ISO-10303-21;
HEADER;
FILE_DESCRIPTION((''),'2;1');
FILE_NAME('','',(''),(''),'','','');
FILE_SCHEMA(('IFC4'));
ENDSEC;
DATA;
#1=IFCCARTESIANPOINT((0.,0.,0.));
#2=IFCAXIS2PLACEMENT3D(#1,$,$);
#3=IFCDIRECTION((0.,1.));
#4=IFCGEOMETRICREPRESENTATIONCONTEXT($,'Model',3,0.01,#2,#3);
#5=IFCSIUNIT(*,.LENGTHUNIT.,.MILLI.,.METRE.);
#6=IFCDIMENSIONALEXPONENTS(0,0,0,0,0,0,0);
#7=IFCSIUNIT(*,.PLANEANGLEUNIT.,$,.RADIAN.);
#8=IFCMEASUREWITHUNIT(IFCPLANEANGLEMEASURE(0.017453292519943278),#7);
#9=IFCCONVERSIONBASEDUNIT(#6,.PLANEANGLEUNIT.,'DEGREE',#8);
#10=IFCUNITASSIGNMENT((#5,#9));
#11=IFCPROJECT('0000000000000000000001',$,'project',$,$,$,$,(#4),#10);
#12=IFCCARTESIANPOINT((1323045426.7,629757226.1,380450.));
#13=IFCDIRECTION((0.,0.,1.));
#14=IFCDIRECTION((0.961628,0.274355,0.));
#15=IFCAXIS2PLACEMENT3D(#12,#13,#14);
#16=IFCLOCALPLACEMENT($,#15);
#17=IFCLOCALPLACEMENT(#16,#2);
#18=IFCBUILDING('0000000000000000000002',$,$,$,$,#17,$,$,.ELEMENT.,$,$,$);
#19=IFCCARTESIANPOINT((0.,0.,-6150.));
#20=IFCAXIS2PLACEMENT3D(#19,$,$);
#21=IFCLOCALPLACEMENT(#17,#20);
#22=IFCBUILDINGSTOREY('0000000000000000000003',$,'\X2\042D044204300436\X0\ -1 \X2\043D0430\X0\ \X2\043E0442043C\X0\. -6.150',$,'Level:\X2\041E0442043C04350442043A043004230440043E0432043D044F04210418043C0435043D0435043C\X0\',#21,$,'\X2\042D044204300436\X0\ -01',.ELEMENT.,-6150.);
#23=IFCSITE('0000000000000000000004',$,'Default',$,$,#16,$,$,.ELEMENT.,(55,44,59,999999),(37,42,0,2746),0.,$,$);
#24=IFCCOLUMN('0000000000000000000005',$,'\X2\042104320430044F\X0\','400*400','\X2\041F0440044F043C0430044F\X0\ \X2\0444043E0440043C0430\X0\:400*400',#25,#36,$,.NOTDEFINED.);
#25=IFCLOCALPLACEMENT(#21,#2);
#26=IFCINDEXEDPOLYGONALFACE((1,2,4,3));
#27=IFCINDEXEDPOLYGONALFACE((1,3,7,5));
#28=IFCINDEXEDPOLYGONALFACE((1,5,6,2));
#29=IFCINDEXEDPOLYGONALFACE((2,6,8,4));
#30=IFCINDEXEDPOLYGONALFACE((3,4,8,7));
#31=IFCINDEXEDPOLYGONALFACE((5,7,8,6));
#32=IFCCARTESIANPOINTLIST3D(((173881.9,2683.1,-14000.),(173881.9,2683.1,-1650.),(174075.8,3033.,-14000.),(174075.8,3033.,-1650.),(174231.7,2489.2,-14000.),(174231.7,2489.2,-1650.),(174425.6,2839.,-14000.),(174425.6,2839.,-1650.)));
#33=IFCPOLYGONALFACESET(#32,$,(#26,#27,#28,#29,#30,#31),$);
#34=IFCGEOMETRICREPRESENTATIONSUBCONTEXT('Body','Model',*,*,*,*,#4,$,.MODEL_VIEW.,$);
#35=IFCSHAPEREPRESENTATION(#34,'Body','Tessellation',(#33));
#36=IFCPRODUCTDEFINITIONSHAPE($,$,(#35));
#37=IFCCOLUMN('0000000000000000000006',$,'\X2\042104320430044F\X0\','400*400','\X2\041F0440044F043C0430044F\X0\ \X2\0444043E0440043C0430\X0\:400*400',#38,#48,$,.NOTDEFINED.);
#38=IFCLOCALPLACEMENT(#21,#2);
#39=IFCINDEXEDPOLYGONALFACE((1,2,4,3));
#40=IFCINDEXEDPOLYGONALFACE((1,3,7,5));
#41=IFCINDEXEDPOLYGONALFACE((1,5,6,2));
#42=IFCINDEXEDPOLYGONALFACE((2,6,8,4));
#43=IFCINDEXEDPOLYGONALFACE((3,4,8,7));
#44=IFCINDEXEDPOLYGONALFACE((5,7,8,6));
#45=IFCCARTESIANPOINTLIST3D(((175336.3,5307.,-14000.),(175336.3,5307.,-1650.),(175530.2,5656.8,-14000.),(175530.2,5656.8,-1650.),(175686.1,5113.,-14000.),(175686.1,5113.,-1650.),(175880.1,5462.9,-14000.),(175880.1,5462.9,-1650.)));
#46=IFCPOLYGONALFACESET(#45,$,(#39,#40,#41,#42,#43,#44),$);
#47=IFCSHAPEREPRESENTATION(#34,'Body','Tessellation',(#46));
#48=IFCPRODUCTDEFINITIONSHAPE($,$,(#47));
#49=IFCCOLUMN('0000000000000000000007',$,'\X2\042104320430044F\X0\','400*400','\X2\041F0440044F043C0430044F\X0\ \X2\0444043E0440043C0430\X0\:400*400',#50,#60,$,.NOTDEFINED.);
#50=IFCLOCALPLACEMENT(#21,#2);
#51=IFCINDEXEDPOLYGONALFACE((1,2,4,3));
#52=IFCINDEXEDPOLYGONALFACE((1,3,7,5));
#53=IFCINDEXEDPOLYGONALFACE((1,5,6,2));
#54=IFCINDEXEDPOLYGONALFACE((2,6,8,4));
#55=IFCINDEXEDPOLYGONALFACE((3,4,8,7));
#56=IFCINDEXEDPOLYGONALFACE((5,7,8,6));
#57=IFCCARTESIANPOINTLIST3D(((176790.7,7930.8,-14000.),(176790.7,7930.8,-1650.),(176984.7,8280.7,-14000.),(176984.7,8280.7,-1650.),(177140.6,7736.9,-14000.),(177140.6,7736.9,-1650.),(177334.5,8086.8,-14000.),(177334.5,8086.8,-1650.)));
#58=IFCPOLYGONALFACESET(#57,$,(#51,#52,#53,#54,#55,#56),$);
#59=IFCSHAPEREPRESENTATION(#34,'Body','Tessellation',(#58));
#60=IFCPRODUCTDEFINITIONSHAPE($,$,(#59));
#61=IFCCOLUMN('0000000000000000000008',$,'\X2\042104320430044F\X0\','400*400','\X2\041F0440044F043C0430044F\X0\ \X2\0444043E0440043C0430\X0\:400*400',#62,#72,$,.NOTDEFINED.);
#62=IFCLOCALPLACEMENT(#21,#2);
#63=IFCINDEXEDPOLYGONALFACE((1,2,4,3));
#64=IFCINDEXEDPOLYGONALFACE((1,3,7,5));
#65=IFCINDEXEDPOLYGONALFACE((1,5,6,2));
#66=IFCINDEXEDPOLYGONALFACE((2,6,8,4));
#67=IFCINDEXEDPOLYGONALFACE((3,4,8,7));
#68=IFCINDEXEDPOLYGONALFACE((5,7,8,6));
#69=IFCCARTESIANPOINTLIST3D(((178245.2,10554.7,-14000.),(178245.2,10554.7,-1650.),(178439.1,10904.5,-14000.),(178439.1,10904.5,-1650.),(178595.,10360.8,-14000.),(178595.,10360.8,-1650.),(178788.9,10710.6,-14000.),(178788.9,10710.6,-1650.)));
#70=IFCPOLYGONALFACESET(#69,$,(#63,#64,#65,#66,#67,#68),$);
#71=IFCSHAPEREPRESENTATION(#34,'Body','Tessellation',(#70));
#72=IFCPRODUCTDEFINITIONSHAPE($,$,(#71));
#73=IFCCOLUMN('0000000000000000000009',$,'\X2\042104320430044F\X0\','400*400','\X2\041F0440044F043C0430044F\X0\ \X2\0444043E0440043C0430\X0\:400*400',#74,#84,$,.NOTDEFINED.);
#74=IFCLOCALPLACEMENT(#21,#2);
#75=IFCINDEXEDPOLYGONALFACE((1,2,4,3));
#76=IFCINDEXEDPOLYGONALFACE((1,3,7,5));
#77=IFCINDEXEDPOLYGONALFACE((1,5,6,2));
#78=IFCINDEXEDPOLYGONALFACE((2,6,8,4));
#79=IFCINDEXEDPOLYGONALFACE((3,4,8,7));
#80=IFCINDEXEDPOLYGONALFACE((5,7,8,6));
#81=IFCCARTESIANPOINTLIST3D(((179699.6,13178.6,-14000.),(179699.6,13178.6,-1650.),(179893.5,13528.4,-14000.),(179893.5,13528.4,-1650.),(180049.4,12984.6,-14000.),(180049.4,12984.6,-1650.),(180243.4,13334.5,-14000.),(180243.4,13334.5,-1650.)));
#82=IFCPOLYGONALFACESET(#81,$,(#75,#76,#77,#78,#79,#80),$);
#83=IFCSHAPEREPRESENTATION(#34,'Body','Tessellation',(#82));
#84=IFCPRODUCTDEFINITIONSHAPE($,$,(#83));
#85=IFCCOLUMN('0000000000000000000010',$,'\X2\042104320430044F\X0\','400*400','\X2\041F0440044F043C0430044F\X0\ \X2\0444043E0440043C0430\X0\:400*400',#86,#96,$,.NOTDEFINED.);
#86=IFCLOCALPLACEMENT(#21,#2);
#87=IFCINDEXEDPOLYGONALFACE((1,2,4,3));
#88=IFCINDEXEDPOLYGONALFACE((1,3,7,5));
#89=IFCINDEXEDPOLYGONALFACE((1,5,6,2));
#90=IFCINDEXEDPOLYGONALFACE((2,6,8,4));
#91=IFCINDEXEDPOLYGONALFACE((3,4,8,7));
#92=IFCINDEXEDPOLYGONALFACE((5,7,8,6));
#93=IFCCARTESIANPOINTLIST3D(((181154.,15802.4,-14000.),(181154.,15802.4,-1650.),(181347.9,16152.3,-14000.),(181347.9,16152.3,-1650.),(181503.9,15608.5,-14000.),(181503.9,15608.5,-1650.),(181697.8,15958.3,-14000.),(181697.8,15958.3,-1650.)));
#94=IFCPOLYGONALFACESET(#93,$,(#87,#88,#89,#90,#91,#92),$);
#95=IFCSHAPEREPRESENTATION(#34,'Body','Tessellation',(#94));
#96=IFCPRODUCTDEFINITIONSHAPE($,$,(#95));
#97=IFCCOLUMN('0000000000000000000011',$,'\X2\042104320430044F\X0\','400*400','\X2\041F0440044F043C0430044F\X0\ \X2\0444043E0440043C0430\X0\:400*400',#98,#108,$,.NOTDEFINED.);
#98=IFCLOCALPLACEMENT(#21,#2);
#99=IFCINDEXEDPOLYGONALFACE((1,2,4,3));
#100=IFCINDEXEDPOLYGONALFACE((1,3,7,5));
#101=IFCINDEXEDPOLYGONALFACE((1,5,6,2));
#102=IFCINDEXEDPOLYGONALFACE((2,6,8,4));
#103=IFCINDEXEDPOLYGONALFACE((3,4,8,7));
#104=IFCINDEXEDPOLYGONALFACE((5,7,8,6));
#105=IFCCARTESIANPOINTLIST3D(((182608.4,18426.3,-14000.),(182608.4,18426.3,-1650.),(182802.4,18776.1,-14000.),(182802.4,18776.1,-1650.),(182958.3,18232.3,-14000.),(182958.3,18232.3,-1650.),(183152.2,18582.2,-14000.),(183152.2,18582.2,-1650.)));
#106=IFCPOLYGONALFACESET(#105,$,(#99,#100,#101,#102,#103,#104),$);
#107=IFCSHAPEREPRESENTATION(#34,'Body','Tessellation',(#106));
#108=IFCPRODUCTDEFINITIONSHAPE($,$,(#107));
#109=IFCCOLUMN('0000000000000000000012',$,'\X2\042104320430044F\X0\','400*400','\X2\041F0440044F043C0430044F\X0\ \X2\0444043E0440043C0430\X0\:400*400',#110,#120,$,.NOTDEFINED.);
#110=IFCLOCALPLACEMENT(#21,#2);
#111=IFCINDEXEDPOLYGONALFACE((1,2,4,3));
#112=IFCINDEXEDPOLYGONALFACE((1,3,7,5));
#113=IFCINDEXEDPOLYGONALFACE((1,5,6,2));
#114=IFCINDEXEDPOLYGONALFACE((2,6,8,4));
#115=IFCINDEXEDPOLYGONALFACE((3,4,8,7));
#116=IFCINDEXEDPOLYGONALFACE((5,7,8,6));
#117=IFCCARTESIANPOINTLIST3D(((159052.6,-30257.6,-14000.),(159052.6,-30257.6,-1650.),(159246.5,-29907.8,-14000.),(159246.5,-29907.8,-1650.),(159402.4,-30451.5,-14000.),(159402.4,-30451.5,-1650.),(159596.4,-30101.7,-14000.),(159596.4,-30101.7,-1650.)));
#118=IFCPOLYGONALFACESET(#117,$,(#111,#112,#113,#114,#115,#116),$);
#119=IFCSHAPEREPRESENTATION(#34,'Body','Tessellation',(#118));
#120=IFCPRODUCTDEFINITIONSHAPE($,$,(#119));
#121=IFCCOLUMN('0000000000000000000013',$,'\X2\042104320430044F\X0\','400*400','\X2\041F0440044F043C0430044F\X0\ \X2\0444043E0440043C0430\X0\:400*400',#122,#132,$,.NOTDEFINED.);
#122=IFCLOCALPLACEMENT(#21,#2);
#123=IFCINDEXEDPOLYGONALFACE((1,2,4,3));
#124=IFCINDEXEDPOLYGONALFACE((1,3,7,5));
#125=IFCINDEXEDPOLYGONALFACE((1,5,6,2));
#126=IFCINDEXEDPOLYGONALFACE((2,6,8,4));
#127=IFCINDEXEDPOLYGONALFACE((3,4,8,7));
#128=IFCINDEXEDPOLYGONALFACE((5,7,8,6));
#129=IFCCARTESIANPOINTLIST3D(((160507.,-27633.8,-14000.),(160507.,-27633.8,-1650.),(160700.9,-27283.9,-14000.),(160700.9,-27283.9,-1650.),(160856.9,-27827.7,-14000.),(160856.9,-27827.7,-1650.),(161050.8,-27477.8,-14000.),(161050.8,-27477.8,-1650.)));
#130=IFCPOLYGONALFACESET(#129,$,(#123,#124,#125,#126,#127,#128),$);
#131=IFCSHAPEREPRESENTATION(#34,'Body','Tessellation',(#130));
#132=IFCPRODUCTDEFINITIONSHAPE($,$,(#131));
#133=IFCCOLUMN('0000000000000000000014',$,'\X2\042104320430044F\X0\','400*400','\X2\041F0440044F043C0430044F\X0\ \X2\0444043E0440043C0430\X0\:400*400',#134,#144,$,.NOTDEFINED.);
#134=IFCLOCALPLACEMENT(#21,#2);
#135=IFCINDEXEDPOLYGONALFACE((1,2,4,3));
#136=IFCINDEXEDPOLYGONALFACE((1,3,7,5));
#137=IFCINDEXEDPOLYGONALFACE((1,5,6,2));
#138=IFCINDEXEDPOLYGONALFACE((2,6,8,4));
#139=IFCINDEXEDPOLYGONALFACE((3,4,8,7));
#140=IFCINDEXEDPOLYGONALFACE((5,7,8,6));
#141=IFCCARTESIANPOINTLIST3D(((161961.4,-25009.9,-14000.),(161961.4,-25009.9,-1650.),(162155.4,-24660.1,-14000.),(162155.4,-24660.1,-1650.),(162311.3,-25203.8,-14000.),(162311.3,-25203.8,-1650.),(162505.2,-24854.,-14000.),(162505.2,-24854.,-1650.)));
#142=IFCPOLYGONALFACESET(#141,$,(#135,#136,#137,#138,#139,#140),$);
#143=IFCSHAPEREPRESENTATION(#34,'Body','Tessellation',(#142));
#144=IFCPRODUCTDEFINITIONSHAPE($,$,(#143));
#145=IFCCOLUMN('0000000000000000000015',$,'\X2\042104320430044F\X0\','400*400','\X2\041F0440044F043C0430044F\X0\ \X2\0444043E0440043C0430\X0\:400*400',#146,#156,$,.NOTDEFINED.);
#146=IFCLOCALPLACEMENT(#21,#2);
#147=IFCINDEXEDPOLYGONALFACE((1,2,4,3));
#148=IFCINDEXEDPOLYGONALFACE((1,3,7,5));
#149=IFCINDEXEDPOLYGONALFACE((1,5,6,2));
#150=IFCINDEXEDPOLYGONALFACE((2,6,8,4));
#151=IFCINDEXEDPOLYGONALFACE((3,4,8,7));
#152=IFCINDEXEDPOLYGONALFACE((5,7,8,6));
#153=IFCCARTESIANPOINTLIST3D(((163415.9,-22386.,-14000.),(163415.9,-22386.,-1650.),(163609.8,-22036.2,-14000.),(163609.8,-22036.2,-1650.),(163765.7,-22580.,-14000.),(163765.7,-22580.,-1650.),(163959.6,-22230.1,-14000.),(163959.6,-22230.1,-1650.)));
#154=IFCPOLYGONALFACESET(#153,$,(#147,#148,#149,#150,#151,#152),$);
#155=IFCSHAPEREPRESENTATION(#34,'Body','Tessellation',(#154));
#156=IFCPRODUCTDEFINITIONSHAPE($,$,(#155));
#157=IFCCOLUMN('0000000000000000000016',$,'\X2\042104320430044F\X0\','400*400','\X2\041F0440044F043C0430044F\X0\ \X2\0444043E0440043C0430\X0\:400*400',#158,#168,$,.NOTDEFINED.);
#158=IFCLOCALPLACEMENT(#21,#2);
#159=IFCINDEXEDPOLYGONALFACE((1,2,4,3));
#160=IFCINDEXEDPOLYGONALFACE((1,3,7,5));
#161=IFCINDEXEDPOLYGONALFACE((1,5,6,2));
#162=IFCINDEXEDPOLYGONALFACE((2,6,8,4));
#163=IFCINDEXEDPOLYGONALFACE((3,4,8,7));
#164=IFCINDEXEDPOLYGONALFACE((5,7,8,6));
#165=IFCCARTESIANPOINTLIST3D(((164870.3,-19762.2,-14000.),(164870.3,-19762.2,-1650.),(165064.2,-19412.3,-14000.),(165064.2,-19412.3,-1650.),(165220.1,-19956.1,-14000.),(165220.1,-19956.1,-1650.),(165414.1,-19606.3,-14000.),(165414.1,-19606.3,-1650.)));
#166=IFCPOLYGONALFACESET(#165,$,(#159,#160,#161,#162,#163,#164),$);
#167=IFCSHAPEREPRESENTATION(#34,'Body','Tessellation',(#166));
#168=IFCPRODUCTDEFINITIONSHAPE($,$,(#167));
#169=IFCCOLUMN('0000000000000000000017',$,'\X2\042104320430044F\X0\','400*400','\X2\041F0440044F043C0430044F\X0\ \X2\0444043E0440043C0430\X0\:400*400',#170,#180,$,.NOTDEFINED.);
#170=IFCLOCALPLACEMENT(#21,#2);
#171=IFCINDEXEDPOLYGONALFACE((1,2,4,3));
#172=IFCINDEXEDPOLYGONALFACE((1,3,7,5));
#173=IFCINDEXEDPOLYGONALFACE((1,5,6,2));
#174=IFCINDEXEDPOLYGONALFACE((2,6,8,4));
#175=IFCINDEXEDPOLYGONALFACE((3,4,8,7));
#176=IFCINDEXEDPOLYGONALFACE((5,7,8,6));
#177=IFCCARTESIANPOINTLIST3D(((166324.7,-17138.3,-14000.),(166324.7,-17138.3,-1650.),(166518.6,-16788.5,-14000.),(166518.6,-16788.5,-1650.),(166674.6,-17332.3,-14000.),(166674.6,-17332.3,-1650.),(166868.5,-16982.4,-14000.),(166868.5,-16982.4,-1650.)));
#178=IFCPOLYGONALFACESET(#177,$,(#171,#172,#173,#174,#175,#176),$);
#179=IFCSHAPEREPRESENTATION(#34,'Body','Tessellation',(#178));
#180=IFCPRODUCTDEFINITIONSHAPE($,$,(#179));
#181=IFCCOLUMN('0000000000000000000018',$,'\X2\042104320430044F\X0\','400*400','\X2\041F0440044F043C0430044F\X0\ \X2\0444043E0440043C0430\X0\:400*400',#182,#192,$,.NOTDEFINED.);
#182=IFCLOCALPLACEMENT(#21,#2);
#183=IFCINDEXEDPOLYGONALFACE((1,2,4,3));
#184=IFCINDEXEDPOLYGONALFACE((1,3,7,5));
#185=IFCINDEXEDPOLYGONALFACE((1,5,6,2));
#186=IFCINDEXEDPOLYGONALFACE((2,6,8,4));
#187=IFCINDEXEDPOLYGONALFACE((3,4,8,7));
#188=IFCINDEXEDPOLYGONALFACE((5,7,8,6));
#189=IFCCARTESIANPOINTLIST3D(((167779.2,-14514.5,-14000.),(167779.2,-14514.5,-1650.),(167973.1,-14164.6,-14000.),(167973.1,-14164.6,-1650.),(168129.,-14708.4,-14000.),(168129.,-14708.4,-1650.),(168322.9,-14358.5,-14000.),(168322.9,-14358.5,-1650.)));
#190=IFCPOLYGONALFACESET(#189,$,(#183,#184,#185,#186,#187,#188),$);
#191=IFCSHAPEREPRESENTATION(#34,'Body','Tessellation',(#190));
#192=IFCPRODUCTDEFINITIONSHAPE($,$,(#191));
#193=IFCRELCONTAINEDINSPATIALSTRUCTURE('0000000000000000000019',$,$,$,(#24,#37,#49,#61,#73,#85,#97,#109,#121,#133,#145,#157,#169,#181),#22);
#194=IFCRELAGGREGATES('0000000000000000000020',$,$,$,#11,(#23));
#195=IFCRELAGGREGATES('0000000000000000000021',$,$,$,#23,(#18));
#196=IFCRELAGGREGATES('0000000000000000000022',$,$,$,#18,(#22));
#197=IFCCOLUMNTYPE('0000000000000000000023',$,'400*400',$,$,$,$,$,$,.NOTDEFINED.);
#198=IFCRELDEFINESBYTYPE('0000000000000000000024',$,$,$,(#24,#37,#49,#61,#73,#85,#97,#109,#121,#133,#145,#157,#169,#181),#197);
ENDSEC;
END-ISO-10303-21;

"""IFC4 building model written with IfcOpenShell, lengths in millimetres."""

from ifc_helpers import new_model, entity, si_unit, converted_unit, direction, frame, origin, place, context, subcontext, project, spatial, indexed_curve, outline, extrude, type_object, element, save


model = new_model("IFC4")

# Units and contexts
model_context = context("Model", 3, precision=0.01, world=origin(), true_north=direction((0.0, 1.0)))
body_context = subcontext(model_context, "Body", "Model", "MODEL_VIEW")
ifc_project = project(units=[si_unit("LENGTHUNIT", "METRE", prefix="MILLI"), converted_unit("PLANEANGLEUNIT", "DEGREE", entity("IfcPlaneAngleMeasure", 0.017453292519943278), si_unit("PLANEANGLEUNIT", "RADIAN"), dimensions=[0, 0, 0, 0, 0, 0, 0])], contexts=[model_context])

# Site, building, storey
site_placement = place(None, frame((1323045426.7, 629757226.1, 380450.0), z_axis=(0.0, 0.0, 1.0), x_axis=(0.961628, 0.274355, 0.0)))
site = spatial("IfcSite", under=ifc_project, at=site_placement, Name="Default", CompositionType="ELEMENT", RefLatitude=(55, 44, 59, 999999), RefLongitude=(37, 42, 0, 2746), RefElevation=0.0)
building_placement = place(site_placement, origin())
building = spatial("IfcBuilding", under=site, at=building_placement, CompositionType="ELEMENT")
storey_placement = place(building_placement, frame((0.0, 0.0, -6150.0)))
storey = spatial("IfcBuildingStorey", under=building, at=storey_placement, Name="Этаж -1 на отм. -6.150", ObjectType="Level:ОтметкаУровняСИменем", LongName="Этаж -01", CompositionType="ELEMENT", Elevation=-6150.0)

# Columns
column_type = type_object("IfcColumnType", Name="400*400", PredefinedType="NOTDEFINED")
column_1_placement = place(storey_placement, origin())
element("IfcColumn", 1, at=column_1_placement, inside=storey, type_object=column_type, Name="Свая", Description="400*400", ObjectType="Прямая форма:400*400", PredefinedType="NOTDEFINED", context=body_context, shape_type="SweptSolid", body=[
    extrude(outline(indexed_curve([(-200.0, -200.0), (200.0, -200.0), (200.0, 200.0), (-200.0, 200.0), (-200.0, -200.0)], self_intersect=False)), frame((174153.8, 2761.1, -14000.0), z_axis=(0.0, 0.0, 1.0), x_axis=(0.48481, 0.87462, 0.0)), (0.0, 0.0, 1.0), 12350.0),
])
column_2_placement = place(storey_placement, origin())
element("IfcColumn", 2, at=column_2_placement, inside=storey, type_object=column_type, Name="Свая", Description="400*400", ObjectType="Прямая форма:400*400", PredefinedType="NOTDEFINED", context=body_context, shape_type="SweptSolid", body=[
    extrude(outline(indexed_curve([(-200.0, -200.0), (200.0, -200.0), (200.0, 200.0), (-200.0, 200.0), (-200.0, -200.0)], self_intersect=False)), frame((175608.2, 5384.9, -14000.0), z_axis=(0.0, 0.0, 1.0), x_axis=(0.48481, 0.87462, 0.0)), (0.0, 0.0, 1.0), 12350.0),
])
column_3_placement = place(storey_placement, origin())
element("IfcColumn", 3, at=column_3_placement, inside=storey, type_object=column_type, Name="Свая", Description="400*400", ObjectType="Прямая форма:400*400", PredefinedType="NOTDEFINED", context=body_context, shape_type="SweptSolid", body=[
    extrude(outline(indexed_curve([(-200.0, -200.0), (200.0, -200.0), (200.0, 200.0), (-200.0, 200.0), (-200.0, -200.0)], self_intersect=False)), frame((177062.6, 8008.8, -14000.0), z_axis=(0.0, 0.0, 1.0), x_axis=(0.48481, 0.87462, 0.0)), (0.0, 0.0, 1.0), 12350.0),
])
column_4_placement = place(storey_placement, origin())
element("IfcColumn", 4, at=column_4_placement, inside=storey, type_object=column_type, Name="Свая", Description="400*400", ObjectType="Прямая форма:400*400", PredefinedType="NOTDEFINED", context=body_context, shape_type="SweptSolid", body=[
    extrude(outline(indexed_curve([(-200.0, -200.0), (200.0, -200.0), (200.0, 200.0), (-200.0, 200.0), (-200.0, -200.0)], self_intersect=False)), frame((178517.0, 10632.7, -14000.0), z_axis=(0.0, 0.0, 1.0), x_axis=(0.48481, 0.87462, 0.0)), (0.0, 0.0, 1.0), 12350.0),
])
column_5_placement = place(storey_placement, origin())
element("IfcColumn", 5, at=column_5_placement, inside=storey, type_object=column_type, Name="Свая", Description="400*400", ObjectType="Прямая форма:400*400", PredefinedType="NOTDEFINED", context=body_context, shape_type="SweptSolid", body=[
    extrude(outline(indexed_curve([(-200.0, -200.0), (200.0, -200.0), (200.0, 200.0), (-200.0, 200.0), (-200.0, -200.0)], self_intersect=False)), frame((179971.5, 13256.5, -14000.0), z_axis=(0.0, 0.0, 1.0), x_axis=(0.48481, 0.87462, 0.0)), (0.0, 0.0, 1.0), 12350.0),
])
column_6_placement = place(storey_placement, origin())
element("IfcColumn", 6, at=column_6_placement, inside=storey, type_object=column_type, Name="Свая", Description="400*400", ObjectType="Прямая форма:400*400", PredefinedType="NOTDEFINED", context=body_context, shape_type="SweptSolid", body=[
    extrude(outline(indexed_curve([(-200.0, -200.0), (200.0, -200.0), (200.0, 200.0), (-200.0, 200.0), (-200.0, -200.0)], self_intersect=False)), frame((181425.9, 15880.4, -14000.0), z_axis=(0.0, 0.0, 1.0), x_axis=(0.48481, 0.87462, 0.0)), (0.0, 0.0, 1.0), 12350.0),
])
column_7_placement = place(storey_placement, origin())
element("IfcColumn", 7, at=column_7_placement, inside=storey, type_object=column_type, Name="Свая", Description="400*400", ObjectType="Прямая форма:400*400", PredefinedType="NOTDEFINED", context=body_context, shape_type="SweptSolid", body=[
    extrude(outline(indexed_curve([(-200.0, -200.0), (200.0, -200.0), (200.0, 200.0), (-200.0, 200.0), (-200.0, -200.0)], self_intersect=False)), frame((182880.3, 18504.2, -14000.0), z_axis=(0.0, 0.0, 1.0), x_axis=(0.48481, 0.87462, 0.0)), (0.0, 0.0, 1.0), 12350.0),
])
column_8_placement = place(storey_placement, origin())
element("IfcColumn", 8, at=column_8_placement, inside=storey, type_object=column_type, Name="Свая", Description="400*400", ObjectType="Прямая форма:400*400", PredefinedType="NOTDEFINED", context=body_context, shape_type="SweptSolid", body=[
    extrude(outline(indexed_curve([(-200.0, -200.0), (200.0, -200.0), (200.0, 200.0), (-200.0, 200.0), (-200.0, -200.0)], self_intersect=False)), frame((159324.5, -30179.7, -14000.0), z_axis=(0.0, 0.0, 1.0), x_axis=(0.48481, 0.87462, 0.0)), (0.0, 0.0, 1.0), 12350.0),
])
column_9_placement = place(storey_placement, origin())
element("IfcColumn", 9, at=column_9_placement, inside=storey, type_object=column_type, Name="Свая", Description="400*400", ObjectType="Прямая форма:400*400", PredefinedType="NOTDEFINED", context=body_context, shape_type="SweptSolid", body=[
    extrude(outline(indexed_curve([(-200.0, -200.0), (200.0, -200.0), (200.0, 200.0), (-200.0, 200.0), (-200.0, -200.0)], self_intersect=False)), frame((160778.9, -27555.8, -14000.0), z_axis=(0.0, 0.0, 1.0), x_axis=(0.48481, 0.87462, 0.0)), (0.0, 0.0, 1.0), 12350.0),
])
column_10_placement = place(storey_placement, origin())
element("IfcColumn", 10, at=column_10_placement, inside=storey, type_object=column_type, Name="Свая", Description="400*400", ObjectType="Прямая форма:400*400", PredefinedType="NOTDEFINED", context=body_context, shape_type="SweptSolid", body=[
    extrude(outline(indexed_curve([(-200.0, -200.0), (200.0, -200.0), (200.0, 200.0), (-200.0, 200.0), (-200.0, -200.0)], self_intersect=False)), frame((162233.3, -24931.9, -14000.0), z_axis=(0.0, 0.0, 1.0), x_axis=(0.48481, 0.87462, 0.0)), (0.0, 0.0, 1.0), 12350.0),
])
column_11_placement = place(storey_placement, origin())
element("IfcColumn", 11, at=column_11_placement, inside=storey, type_object=column_type, Name="Свая", Description="400*400", ObjectType="Прямая форма:400*400", PredefinedType="NOTDEFINED", context=body_context, shape_type="SweptSolid", body=[
    extrude(outline(indexed_curve([(-200.0, -200.0), (200.0, -200.0), (200.0, 200.0), (-200.0, 200.0), (-200.0, -200.0)], self_intersect=False)), frame((163687.8, -22308.1, -14000.0), z_axis=(0.0, 0.0, 1.0), x_axis=(0.48481, 0.87462, 0.0)), (0.0, 0.0, 1.0), 12350.0),
])
column_12_placement = place(storey_placement, origin())
element("IfcColumn", 12, at=column_12_placement, inside=storey, type_object=column_type, Name="Свая", Description="400*400", ObjectType="Прямая форма:400*400", PredefinedType="NOTDEFINED", context=body_context, shape_type="SweptSolid", body=[
    extrude(outline(indexed_curve([(-200.0, -200.0), (200.0, -200.0), (200.0, 200.0), (-200.0, 200.0), (-200.0, -200.0)], self_intersect=False)), frame((165142.2, -19684.2, -14000.0), z_axis=(0.0, 0.0, 1.0), x_axis=(0.48481, 0.87462, 0.0)), (0.0, 0.0, 1.0), 12350.0),
])
column_13_placement = place(storey_placement, origin())
element("IfcColumn", 13, at=column_13_placement, inside=storey, type_object=column_type, Name="Свая", Description="400*400", ObjectType="Прямая форма:400*400", PredefinedType="NOTDEFINED", context=body_context, shape_type="SweptSolid", body=[
    extrude(outline(indexed_curve([(-200.0, -200.0), (200.0, -200.0), (200.0, 200.0), (-200.0, 200.0), (-200.0, -200.0)], self_intersect=False)), frame((166596.6, -17060.4, -14000.0), z_axis=(0.0, 0.0, 1.0), x_axis=(0.48481, 0.87462, 0.0)), (0.0, 0.0, 1.0), 12350.0),
])
column_14_placement = place(storey_placement, origin())
element("IfcColumn", 14, at=column_14_placement, inside=storey, type_object=column_type, Name="Свая", Description="400*400", ObjectType="Прямая форма:400*400", PredefinedType="NOTDEFINED", context=body_context, shape_type="SweptSolid", body=[
    extrude(outline(indexed_curve([(-200.0, -200.0), (200.0, -200.0), (200.0, 200.0), (-200.0, 200.0), (-200.0, -200.0)], self_intersect=False)), frame((168051.0, -14436.5, -14000.0), z_axis=(0.0, 0.0, 1.0), x_axis=(0.48481, 0.87462, 0.0)), (0.0, 0.0, 1.0), 12350.0),
])

save(model, "model.ifc")
